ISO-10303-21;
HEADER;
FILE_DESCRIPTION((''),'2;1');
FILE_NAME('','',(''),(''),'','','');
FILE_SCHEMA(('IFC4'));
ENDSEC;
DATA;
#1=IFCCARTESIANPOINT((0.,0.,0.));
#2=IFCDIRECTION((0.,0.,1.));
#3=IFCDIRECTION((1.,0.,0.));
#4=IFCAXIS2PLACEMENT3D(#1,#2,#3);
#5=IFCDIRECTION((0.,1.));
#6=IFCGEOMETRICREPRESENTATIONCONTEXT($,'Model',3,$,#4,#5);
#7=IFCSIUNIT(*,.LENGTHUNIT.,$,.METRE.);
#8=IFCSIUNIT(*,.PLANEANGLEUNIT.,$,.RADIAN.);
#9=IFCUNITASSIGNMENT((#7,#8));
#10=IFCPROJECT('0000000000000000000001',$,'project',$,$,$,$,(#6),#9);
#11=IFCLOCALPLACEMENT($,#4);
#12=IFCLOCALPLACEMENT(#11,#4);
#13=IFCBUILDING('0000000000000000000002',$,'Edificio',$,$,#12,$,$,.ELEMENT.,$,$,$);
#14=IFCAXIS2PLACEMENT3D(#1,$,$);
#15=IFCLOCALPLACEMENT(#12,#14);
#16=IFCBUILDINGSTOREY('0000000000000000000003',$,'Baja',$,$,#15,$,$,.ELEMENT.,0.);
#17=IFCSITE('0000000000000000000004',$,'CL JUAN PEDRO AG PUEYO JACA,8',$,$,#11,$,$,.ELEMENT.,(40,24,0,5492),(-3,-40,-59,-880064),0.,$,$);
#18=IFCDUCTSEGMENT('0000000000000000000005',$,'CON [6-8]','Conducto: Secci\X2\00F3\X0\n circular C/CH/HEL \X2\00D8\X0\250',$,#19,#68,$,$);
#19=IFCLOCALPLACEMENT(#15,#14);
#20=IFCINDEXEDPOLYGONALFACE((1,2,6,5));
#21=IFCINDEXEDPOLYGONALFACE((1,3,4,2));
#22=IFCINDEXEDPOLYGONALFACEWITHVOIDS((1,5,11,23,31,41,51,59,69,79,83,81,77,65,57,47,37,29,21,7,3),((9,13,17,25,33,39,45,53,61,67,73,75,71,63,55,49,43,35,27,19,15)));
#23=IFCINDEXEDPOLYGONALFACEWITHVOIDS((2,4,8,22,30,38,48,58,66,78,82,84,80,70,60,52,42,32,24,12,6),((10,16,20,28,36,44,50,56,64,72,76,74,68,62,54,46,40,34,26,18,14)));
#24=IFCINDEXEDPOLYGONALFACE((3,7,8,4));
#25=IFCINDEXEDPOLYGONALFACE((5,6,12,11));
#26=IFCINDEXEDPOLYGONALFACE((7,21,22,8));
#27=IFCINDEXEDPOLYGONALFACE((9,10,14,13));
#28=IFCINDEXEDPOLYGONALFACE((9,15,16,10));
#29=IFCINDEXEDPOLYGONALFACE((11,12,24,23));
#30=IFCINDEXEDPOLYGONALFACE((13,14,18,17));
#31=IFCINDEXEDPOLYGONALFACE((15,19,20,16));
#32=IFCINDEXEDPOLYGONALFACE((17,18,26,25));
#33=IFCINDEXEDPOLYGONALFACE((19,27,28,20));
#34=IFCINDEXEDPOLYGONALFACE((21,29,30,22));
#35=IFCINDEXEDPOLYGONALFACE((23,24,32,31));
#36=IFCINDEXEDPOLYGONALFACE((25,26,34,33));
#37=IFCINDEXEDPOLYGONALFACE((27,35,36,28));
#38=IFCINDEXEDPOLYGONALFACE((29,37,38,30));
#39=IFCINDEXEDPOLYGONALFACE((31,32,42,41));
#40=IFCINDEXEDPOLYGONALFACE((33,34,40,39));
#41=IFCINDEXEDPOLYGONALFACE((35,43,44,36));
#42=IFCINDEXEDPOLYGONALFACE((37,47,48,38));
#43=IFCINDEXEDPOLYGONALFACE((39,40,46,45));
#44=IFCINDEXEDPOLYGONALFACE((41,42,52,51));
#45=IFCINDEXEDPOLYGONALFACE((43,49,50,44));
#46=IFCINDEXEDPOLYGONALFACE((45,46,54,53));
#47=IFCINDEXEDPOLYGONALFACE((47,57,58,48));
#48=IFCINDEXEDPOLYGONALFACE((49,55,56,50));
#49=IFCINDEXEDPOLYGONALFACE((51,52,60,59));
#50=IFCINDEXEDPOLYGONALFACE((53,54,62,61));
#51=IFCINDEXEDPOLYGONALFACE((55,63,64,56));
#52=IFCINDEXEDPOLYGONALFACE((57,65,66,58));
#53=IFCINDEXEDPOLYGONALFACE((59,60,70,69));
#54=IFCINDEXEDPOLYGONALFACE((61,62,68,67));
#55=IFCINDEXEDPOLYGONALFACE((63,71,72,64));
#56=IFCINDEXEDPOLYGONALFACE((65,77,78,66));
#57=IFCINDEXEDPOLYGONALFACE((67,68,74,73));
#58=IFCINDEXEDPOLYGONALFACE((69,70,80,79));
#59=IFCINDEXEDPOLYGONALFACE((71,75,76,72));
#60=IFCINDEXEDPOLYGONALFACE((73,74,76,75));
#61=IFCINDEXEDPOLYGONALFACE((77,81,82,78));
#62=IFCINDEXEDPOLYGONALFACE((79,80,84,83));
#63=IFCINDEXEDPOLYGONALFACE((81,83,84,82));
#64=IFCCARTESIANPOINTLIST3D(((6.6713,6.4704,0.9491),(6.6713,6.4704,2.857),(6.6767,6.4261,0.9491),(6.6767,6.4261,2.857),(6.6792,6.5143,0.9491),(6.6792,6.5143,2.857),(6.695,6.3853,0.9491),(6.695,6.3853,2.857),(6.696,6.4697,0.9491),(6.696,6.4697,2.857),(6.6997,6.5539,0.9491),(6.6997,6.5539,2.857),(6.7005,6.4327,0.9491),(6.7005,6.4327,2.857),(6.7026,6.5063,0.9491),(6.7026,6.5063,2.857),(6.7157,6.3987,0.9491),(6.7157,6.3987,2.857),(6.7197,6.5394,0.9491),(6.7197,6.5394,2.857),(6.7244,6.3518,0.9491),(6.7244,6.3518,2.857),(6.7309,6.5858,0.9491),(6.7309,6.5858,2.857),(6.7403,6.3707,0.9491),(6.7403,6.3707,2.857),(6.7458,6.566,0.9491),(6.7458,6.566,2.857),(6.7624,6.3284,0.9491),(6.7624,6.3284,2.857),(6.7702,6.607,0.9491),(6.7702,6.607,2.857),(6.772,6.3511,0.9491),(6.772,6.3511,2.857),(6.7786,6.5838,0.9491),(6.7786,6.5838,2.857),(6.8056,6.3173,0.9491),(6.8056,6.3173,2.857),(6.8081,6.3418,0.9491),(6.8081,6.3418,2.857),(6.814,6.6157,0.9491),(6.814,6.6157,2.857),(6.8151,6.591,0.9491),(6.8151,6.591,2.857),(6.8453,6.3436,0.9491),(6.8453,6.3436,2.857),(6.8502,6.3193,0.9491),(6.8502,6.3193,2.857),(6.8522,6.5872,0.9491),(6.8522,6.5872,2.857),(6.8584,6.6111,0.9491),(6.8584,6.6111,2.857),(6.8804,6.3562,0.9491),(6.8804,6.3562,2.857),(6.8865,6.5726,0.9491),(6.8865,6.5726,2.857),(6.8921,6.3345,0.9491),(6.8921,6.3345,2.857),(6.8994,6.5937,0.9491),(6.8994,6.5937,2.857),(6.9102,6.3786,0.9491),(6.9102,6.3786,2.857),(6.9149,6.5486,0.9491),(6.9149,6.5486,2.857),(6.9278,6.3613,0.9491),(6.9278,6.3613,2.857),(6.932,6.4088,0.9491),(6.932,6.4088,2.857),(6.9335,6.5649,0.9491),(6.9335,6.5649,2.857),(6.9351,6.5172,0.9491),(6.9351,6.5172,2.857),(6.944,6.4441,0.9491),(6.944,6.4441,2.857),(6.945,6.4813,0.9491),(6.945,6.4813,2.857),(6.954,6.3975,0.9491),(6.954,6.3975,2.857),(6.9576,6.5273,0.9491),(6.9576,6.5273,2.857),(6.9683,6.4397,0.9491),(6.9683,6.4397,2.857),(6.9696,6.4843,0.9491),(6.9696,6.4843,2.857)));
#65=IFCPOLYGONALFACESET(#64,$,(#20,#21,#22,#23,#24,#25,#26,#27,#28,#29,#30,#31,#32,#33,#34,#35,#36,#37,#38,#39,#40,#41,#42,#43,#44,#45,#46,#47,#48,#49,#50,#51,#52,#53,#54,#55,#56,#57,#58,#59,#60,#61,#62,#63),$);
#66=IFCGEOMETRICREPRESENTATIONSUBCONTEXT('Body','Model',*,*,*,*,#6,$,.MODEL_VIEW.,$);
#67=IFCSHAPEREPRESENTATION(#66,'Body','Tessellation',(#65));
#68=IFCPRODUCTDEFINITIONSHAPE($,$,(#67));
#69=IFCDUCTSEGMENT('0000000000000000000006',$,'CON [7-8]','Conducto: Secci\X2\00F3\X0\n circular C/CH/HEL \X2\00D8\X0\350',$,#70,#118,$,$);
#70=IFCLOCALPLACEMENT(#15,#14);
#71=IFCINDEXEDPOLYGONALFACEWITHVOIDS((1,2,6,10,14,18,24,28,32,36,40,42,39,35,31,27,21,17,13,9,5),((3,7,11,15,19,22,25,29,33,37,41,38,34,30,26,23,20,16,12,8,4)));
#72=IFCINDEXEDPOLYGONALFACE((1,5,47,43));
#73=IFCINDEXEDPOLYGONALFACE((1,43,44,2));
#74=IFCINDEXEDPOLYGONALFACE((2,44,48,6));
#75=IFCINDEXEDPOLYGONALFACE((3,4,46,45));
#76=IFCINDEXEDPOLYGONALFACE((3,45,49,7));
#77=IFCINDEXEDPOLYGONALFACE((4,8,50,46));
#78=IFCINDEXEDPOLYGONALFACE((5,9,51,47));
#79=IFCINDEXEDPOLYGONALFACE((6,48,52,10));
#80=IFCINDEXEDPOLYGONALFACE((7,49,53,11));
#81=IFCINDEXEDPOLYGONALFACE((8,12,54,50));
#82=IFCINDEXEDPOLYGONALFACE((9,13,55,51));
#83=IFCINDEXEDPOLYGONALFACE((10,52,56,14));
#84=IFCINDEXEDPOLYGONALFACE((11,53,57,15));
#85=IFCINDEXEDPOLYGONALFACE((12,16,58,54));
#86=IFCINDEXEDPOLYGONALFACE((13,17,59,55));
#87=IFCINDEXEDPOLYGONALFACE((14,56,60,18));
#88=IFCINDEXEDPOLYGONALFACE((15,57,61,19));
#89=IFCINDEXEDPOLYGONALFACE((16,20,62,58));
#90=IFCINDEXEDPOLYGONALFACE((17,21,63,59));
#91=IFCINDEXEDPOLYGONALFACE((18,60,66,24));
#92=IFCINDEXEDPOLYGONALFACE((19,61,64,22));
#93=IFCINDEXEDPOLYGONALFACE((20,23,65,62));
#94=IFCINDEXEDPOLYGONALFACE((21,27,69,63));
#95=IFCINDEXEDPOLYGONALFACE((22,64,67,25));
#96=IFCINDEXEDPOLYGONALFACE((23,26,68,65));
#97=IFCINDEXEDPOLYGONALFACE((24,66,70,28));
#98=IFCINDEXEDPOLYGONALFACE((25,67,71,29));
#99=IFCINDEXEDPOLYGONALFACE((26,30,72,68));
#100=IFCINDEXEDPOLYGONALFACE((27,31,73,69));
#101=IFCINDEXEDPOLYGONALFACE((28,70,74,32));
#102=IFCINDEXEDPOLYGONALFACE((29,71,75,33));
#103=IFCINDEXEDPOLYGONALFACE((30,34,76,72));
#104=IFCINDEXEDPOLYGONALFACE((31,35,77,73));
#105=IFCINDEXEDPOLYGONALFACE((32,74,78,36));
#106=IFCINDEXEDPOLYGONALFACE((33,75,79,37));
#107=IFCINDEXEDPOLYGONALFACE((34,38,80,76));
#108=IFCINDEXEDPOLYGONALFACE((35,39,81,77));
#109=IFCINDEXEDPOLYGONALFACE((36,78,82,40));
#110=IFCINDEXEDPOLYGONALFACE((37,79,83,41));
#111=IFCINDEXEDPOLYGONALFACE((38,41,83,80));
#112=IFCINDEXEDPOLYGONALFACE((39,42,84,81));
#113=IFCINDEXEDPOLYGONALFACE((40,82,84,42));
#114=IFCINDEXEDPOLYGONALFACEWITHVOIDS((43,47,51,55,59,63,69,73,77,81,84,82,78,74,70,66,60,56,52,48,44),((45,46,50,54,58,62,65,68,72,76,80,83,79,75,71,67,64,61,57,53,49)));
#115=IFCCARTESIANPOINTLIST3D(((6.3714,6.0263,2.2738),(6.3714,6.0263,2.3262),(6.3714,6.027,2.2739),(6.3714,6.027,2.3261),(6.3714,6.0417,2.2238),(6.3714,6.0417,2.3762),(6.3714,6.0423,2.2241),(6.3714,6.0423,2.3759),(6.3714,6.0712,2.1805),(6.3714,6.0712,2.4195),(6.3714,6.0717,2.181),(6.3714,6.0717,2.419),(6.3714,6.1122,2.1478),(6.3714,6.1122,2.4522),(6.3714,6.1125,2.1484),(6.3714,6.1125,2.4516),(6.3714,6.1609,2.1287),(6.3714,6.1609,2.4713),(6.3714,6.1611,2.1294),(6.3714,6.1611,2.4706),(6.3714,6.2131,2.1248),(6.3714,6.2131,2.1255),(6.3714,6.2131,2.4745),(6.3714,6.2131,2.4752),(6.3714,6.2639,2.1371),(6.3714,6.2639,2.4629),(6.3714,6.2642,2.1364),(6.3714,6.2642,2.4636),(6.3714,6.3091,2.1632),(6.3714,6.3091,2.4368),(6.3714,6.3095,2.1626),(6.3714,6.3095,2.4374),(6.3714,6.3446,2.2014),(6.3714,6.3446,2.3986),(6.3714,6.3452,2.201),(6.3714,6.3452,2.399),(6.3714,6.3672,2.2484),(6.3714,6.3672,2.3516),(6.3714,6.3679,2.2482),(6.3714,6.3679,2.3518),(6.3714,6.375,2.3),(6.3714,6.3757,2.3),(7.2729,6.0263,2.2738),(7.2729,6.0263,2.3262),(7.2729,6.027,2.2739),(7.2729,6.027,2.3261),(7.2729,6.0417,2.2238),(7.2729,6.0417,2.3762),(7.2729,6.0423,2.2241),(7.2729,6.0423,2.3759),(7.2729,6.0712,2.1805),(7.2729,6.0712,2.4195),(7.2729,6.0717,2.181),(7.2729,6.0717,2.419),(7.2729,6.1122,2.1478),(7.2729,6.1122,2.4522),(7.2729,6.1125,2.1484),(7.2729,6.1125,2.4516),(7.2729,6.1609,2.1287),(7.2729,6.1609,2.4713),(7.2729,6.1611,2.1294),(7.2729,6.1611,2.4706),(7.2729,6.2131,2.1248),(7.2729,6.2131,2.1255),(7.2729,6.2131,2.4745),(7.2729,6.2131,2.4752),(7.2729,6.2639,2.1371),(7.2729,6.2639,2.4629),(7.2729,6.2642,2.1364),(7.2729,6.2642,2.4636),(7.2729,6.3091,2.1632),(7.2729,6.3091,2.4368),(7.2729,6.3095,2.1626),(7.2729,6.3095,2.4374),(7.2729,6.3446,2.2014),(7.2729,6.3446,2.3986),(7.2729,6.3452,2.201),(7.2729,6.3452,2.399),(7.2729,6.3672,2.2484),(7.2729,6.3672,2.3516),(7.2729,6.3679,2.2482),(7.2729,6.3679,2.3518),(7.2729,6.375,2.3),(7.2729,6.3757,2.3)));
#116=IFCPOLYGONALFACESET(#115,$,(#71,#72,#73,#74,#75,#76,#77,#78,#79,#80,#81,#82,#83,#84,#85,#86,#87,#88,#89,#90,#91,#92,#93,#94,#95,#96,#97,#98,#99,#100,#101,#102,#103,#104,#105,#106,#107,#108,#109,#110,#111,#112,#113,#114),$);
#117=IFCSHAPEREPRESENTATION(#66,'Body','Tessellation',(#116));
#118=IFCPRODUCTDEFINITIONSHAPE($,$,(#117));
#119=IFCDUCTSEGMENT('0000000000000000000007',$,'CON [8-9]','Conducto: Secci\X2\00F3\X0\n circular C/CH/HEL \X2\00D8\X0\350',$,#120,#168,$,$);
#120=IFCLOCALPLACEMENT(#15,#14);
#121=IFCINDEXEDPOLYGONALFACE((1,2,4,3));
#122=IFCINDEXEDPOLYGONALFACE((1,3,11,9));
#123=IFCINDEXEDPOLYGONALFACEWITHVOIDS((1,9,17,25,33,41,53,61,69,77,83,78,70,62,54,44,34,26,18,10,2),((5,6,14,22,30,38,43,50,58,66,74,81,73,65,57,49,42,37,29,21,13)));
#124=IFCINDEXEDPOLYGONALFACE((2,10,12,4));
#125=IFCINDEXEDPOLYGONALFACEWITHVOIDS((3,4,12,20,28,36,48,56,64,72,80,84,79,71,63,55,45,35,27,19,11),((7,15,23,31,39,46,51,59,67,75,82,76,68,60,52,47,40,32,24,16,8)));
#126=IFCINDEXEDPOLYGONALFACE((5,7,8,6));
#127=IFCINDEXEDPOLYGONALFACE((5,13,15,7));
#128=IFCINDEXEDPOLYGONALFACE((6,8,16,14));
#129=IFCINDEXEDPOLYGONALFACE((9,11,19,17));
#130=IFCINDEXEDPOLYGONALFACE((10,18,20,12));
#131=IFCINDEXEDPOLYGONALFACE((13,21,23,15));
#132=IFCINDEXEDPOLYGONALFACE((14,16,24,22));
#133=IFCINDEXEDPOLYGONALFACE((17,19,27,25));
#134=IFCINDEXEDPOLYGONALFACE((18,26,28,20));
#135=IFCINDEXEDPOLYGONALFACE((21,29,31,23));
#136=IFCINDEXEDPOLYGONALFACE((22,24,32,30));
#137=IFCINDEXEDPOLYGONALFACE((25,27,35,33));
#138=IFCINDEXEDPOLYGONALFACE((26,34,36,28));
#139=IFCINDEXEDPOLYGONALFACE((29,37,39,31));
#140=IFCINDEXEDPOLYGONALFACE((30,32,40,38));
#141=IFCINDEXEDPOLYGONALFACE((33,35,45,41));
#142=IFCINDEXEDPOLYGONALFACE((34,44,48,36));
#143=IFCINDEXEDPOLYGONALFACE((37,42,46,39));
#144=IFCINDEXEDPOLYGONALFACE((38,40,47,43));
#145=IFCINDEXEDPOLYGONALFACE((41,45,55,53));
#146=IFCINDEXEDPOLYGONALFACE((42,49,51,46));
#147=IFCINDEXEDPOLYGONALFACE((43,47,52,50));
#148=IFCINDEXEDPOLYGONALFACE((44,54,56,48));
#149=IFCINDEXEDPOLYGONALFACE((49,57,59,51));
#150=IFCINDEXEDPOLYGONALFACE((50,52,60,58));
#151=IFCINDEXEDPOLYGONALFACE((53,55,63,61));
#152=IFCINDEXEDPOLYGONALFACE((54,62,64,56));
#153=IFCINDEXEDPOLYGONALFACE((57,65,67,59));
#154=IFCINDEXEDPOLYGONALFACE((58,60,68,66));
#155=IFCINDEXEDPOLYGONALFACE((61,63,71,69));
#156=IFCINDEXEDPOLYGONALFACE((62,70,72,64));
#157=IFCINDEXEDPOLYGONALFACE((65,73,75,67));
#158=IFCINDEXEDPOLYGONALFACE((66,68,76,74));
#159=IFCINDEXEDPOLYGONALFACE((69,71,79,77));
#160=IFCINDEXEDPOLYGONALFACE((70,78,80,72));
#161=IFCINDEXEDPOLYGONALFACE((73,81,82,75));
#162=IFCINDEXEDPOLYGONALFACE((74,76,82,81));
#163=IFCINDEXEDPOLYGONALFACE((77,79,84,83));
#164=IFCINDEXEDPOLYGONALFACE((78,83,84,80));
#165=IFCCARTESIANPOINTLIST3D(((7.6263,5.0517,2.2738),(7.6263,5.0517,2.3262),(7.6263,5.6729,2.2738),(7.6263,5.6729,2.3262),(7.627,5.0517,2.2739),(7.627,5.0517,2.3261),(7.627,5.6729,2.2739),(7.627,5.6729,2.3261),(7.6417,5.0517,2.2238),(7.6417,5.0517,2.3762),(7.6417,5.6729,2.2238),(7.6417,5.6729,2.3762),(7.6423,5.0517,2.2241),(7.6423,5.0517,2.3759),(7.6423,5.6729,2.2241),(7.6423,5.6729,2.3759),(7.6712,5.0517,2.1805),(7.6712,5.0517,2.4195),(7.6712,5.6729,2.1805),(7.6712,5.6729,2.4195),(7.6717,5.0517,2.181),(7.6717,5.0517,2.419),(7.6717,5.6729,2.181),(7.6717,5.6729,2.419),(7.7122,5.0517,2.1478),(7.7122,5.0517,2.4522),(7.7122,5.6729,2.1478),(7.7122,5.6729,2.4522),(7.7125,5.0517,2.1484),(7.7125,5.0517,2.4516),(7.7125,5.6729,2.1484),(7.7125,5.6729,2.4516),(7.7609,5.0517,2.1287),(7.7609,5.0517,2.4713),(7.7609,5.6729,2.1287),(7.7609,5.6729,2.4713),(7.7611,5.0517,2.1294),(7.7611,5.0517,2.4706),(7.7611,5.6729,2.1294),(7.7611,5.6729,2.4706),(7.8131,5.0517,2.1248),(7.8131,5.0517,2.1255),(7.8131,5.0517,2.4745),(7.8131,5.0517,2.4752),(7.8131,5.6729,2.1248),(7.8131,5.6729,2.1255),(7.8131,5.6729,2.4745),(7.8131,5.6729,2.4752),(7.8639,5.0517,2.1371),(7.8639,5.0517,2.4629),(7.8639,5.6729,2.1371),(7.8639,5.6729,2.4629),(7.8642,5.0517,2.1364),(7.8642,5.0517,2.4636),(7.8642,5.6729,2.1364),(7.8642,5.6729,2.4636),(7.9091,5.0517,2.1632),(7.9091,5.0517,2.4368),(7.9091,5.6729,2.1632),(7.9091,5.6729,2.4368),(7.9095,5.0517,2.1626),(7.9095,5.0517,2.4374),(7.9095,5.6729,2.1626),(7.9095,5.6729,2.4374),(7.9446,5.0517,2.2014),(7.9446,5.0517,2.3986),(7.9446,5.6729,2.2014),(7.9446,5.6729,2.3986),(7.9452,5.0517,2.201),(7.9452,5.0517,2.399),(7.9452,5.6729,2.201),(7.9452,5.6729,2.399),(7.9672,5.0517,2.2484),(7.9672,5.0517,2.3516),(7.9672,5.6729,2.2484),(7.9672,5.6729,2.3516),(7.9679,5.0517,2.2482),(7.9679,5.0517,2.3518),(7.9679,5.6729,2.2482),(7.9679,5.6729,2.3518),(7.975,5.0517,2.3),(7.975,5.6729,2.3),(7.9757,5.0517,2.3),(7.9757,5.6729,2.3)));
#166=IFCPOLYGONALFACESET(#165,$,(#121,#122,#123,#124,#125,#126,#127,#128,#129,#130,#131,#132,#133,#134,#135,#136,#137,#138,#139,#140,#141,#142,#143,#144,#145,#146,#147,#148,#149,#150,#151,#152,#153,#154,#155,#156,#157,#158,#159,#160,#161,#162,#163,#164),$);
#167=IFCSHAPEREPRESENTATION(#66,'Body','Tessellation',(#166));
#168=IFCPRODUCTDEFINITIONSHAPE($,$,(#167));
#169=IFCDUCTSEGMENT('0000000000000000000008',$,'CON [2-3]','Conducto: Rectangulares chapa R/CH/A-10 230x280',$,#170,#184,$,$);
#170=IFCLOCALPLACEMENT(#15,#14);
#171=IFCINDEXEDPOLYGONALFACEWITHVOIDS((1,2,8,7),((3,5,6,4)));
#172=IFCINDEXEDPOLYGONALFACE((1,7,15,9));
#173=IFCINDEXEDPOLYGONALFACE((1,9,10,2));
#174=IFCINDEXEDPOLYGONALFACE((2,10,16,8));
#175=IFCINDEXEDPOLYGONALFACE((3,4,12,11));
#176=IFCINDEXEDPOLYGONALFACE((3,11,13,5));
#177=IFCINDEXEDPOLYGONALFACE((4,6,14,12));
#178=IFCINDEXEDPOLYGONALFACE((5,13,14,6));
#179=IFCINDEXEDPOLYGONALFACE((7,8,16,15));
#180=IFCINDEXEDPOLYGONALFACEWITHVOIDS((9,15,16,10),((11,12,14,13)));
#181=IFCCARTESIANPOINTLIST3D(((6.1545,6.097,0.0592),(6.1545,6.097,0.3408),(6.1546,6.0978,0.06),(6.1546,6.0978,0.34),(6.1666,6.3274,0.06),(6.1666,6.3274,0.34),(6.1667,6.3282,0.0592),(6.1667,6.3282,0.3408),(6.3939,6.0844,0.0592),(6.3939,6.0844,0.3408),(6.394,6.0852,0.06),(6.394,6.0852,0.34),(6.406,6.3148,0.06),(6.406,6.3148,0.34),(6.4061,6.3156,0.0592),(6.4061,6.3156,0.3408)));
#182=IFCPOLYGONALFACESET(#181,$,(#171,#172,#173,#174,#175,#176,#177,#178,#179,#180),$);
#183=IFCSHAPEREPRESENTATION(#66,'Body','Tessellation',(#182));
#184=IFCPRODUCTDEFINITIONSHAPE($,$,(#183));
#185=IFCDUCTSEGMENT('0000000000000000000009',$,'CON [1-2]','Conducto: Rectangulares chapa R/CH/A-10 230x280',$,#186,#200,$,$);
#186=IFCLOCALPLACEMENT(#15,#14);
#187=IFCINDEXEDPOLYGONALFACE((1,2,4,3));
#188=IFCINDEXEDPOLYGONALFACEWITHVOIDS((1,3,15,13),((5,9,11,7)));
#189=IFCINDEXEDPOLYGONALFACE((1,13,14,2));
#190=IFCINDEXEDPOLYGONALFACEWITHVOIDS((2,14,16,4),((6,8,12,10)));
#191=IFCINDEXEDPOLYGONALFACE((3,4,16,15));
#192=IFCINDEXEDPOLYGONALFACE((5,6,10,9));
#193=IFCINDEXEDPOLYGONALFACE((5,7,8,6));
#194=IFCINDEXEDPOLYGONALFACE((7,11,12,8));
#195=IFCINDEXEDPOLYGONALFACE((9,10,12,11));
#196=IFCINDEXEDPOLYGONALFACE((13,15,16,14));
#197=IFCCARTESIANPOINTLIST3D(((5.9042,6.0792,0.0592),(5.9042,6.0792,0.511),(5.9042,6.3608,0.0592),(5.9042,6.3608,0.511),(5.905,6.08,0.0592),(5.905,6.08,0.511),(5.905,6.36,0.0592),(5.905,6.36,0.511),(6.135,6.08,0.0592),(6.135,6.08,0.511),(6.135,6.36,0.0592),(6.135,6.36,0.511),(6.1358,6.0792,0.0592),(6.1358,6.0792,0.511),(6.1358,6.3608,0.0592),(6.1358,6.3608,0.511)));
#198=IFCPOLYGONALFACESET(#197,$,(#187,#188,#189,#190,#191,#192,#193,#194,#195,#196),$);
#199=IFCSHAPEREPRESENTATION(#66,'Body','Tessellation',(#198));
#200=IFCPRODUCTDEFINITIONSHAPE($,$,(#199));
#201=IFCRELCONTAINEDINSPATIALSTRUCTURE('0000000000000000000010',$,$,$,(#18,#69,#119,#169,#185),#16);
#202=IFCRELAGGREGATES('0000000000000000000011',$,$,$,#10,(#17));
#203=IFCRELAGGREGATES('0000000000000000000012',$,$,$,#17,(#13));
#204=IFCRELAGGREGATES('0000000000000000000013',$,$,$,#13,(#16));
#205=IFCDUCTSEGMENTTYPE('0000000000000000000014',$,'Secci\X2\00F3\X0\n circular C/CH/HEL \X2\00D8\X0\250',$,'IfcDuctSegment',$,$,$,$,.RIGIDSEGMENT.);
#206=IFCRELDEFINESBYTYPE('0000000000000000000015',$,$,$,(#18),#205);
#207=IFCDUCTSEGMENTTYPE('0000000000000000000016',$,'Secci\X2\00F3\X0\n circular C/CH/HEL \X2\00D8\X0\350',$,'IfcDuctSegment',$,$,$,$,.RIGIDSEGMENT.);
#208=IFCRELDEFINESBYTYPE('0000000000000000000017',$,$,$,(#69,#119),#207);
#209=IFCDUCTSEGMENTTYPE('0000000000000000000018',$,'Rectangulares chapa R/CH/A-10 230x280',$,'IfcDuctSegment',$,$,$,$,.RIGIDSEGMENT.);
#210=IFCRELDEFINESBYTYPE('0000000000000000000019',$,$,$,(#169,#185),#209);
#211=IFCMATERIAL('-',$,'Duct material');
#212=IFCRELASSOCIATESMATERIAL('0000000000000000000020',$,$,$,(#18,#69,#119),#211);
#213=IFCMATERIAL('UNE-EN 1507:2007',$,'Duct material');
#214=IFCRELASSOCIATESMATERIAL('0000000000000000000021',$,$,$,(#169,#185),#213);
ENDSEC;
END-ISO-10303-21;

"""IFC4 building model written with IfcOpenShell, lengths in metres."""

from ifc_helpers import new_model, si_unit, direction, frame, origin, origin_with_axes, origin_2d_with_axis, place, context, subcontext, project, spatial, hollow_rectangle, hollow_circle, extrude, material, type_object, element, save


model = new_model("IFC4")

# Units and contexts
model_context = context("Model", 3, world=origin_with_axes(), true_north=direction((0.0, 1.0)))
body_context = subcontext(model_context, "Body", "Model", "MODEL_VIEW")
ifc_project = project(units=[si_unit("LENGTHUNIT", "METRE"), si_unit("PLANEANGLEUNIT", "RADIAN")], contexts=[model_context])

# Site, building, storey
site_placement = place(None, origin_with_axes())
site = spatial("IfcSite", under=ifc_project, at=site_placement, Name="CL JUAN PEDRO AG PUEYO JACA,8", CompositionType="ELEMENT", RefLatitude=(40, 24, 0, 5492), RefLongitude=(-3, -40, -59, -880064), RefElevation=0.0)
building_placement = place(site_placement, origin_with_axes())
building = spatial("IfcBuilding", under=site, at=building_placement, Name="Edificio", CompositionType="ELEMENT")
storey_placement = place(building_placement, origin())
storey = spatial("IfcBuildingStorey", under=building, at=storey_placement, Name="Baja", CompositionType="ELEMENT", Elevation=0.0)

# Duct segments
ifc_material_1 = material(Name="-", Category="Duct material")
ifc_material_2 = material(Name="UNE-EN 1507:2007", Category="Duct material")
duct_segment_type_1 = type_object("IfcDuctSegmentType", Name="Sección circular C/CH/HEL Ø250", ApplicableOccurrence="IfcDuctSegment", PredefinedType="RIGIDSEGMENT")
duct_segment_1_placement = place(storey_placement, origin_with_axes())
element("IfcDuctSegment", 1, at=duct_segment_1_placement, inside=storey, type_object=duct_segment_type_1, material=ifc_material_1, Name="CON [6-8]", Description="Conducto: Sección circular C/CH/HEL Ø250", context=body_context, shape_type="SweptSolid", body=[
    extrude(hollow_circle(Radius=0.1497, WallThickness=0.0247, at=origin_2d_with_axis()), frame((6.821, 6.4662, 2.857), z_axis=(0.0, 0.0, -1.0), x_axis=(-0.046731, 0.998907, 0.0)), (0.0, 0.0, 1.0), 1.9079),
])
duct_segment_type_2 = type_object("IfcDuctSegmentType", Name="Sección circular C/CH/HEL Ø350", ApplicableOccurrence="IfcDuctSegment", PredefinedType="RIGIDSEGMENT")
duct_segment_2_placement = place(storey_placement, origin_with_axes())
element("IfcDuctSegment", 2, at=duct_segment_2_placement, inside=storey, type_object=duct_segment_type_2, material=ifc_material_1, Name="CON [7-8]", Description="Conducto: Sección circular C/CH/HEL Ø350", context=body_context, shape_type="SweptSolid", body=[
    extrude(hollow_circle(Radius=0.1757, WallThickness=0.0007, at=origin_2d_with_axis()), frame((6.3714, 6.2, 2.3), z_axis=(1.0, 0.0, 0.0), x_axis=(0.0, 1.0, 0.0)), (0.0, 0.0, 1.0), 0.9015),
])
duct_segment_3_placement = place(storey_placement, origin_with_axes())
element("IfcDuctSegment", 3, at=duct_segment_3_placement, inside=storey, type_object=duct_segment_type_2, material=ifc_material_1, Name="CON [8-9]", Description="Conducto: Sección circular C/CH/HEL Ø350", context=body_context, shape_type="SweptSolid", body=[
    extrude(hollow_circle(Radius=0.1757, WallThickness=0.0007, at=origin_2d_with_axis()), frame((7.8, 5.6729, 2.3), z_axis=(0.0, -1.0, 0.0), x_axis=(1.0, 0.0, 0.0)), (0.0, 0.0, 1.0), 0.6212),
])
duct_segment_type_3 = type_object("IfcDuctSegmentType", Name="Rectangulares chapa R/CH/A-10 230x280", ApplicableOccurrence="IfcDuctSegment", PredefinedType="RIGIDSEGMENT")
duct_segment_4_placement = place(storey_placement, origin_with_axes())
element("IfcDuctSegment", 4, at=duct_segment_4_placement, inside=storey, type_object=duct_segment_type_3, material=ifc_material_2, Name="CON [2-3]", Description="Conducto: Rectangulares chapa R/CH/A-10 230x280", context=body_context, shape_type="SweptSolid", body=[
    extrude(hollow_rectangle(XDim=0.2316, YDim=0.2816, WallThickness=0.0008, at=origin_2d_with_axis()), frame((6.1606, 6.2126, 0.2), z_axis=(0.998618, -0.052559, 0.0), x_axis=(0.052559, 0.998618, 0.0)), (0.0, 0.0, 1.0), 0.2397),
])
duct_segment_5_placement = place(storey_placement, origin_with_axes())
element("IfcDuctSegment", 5, at=duct_segment_5_placement, inside=storey, type_object=duct_segment_type_3, material=ifc_material_2, Name="CON [1-2]", Description="Conducto: Rectangulares chapa R/CH/A-10 230x280", context=body_context, shape_type="SweptSolid", body=[
    extrude(hollow_rectangle(XDim=0.2316, YDim=0.2816, WallThickness=0.0008, at=origin_2d_with_axis()), frame((6.02, 6.22, 0.511), z_axis=(0.0, 0.0, -1.0), x_axis=(-1.0, 0.0, 0.0)), (0.0, 0.0, 1.0), 0.4518),
])

save(model, "model.ifc")
